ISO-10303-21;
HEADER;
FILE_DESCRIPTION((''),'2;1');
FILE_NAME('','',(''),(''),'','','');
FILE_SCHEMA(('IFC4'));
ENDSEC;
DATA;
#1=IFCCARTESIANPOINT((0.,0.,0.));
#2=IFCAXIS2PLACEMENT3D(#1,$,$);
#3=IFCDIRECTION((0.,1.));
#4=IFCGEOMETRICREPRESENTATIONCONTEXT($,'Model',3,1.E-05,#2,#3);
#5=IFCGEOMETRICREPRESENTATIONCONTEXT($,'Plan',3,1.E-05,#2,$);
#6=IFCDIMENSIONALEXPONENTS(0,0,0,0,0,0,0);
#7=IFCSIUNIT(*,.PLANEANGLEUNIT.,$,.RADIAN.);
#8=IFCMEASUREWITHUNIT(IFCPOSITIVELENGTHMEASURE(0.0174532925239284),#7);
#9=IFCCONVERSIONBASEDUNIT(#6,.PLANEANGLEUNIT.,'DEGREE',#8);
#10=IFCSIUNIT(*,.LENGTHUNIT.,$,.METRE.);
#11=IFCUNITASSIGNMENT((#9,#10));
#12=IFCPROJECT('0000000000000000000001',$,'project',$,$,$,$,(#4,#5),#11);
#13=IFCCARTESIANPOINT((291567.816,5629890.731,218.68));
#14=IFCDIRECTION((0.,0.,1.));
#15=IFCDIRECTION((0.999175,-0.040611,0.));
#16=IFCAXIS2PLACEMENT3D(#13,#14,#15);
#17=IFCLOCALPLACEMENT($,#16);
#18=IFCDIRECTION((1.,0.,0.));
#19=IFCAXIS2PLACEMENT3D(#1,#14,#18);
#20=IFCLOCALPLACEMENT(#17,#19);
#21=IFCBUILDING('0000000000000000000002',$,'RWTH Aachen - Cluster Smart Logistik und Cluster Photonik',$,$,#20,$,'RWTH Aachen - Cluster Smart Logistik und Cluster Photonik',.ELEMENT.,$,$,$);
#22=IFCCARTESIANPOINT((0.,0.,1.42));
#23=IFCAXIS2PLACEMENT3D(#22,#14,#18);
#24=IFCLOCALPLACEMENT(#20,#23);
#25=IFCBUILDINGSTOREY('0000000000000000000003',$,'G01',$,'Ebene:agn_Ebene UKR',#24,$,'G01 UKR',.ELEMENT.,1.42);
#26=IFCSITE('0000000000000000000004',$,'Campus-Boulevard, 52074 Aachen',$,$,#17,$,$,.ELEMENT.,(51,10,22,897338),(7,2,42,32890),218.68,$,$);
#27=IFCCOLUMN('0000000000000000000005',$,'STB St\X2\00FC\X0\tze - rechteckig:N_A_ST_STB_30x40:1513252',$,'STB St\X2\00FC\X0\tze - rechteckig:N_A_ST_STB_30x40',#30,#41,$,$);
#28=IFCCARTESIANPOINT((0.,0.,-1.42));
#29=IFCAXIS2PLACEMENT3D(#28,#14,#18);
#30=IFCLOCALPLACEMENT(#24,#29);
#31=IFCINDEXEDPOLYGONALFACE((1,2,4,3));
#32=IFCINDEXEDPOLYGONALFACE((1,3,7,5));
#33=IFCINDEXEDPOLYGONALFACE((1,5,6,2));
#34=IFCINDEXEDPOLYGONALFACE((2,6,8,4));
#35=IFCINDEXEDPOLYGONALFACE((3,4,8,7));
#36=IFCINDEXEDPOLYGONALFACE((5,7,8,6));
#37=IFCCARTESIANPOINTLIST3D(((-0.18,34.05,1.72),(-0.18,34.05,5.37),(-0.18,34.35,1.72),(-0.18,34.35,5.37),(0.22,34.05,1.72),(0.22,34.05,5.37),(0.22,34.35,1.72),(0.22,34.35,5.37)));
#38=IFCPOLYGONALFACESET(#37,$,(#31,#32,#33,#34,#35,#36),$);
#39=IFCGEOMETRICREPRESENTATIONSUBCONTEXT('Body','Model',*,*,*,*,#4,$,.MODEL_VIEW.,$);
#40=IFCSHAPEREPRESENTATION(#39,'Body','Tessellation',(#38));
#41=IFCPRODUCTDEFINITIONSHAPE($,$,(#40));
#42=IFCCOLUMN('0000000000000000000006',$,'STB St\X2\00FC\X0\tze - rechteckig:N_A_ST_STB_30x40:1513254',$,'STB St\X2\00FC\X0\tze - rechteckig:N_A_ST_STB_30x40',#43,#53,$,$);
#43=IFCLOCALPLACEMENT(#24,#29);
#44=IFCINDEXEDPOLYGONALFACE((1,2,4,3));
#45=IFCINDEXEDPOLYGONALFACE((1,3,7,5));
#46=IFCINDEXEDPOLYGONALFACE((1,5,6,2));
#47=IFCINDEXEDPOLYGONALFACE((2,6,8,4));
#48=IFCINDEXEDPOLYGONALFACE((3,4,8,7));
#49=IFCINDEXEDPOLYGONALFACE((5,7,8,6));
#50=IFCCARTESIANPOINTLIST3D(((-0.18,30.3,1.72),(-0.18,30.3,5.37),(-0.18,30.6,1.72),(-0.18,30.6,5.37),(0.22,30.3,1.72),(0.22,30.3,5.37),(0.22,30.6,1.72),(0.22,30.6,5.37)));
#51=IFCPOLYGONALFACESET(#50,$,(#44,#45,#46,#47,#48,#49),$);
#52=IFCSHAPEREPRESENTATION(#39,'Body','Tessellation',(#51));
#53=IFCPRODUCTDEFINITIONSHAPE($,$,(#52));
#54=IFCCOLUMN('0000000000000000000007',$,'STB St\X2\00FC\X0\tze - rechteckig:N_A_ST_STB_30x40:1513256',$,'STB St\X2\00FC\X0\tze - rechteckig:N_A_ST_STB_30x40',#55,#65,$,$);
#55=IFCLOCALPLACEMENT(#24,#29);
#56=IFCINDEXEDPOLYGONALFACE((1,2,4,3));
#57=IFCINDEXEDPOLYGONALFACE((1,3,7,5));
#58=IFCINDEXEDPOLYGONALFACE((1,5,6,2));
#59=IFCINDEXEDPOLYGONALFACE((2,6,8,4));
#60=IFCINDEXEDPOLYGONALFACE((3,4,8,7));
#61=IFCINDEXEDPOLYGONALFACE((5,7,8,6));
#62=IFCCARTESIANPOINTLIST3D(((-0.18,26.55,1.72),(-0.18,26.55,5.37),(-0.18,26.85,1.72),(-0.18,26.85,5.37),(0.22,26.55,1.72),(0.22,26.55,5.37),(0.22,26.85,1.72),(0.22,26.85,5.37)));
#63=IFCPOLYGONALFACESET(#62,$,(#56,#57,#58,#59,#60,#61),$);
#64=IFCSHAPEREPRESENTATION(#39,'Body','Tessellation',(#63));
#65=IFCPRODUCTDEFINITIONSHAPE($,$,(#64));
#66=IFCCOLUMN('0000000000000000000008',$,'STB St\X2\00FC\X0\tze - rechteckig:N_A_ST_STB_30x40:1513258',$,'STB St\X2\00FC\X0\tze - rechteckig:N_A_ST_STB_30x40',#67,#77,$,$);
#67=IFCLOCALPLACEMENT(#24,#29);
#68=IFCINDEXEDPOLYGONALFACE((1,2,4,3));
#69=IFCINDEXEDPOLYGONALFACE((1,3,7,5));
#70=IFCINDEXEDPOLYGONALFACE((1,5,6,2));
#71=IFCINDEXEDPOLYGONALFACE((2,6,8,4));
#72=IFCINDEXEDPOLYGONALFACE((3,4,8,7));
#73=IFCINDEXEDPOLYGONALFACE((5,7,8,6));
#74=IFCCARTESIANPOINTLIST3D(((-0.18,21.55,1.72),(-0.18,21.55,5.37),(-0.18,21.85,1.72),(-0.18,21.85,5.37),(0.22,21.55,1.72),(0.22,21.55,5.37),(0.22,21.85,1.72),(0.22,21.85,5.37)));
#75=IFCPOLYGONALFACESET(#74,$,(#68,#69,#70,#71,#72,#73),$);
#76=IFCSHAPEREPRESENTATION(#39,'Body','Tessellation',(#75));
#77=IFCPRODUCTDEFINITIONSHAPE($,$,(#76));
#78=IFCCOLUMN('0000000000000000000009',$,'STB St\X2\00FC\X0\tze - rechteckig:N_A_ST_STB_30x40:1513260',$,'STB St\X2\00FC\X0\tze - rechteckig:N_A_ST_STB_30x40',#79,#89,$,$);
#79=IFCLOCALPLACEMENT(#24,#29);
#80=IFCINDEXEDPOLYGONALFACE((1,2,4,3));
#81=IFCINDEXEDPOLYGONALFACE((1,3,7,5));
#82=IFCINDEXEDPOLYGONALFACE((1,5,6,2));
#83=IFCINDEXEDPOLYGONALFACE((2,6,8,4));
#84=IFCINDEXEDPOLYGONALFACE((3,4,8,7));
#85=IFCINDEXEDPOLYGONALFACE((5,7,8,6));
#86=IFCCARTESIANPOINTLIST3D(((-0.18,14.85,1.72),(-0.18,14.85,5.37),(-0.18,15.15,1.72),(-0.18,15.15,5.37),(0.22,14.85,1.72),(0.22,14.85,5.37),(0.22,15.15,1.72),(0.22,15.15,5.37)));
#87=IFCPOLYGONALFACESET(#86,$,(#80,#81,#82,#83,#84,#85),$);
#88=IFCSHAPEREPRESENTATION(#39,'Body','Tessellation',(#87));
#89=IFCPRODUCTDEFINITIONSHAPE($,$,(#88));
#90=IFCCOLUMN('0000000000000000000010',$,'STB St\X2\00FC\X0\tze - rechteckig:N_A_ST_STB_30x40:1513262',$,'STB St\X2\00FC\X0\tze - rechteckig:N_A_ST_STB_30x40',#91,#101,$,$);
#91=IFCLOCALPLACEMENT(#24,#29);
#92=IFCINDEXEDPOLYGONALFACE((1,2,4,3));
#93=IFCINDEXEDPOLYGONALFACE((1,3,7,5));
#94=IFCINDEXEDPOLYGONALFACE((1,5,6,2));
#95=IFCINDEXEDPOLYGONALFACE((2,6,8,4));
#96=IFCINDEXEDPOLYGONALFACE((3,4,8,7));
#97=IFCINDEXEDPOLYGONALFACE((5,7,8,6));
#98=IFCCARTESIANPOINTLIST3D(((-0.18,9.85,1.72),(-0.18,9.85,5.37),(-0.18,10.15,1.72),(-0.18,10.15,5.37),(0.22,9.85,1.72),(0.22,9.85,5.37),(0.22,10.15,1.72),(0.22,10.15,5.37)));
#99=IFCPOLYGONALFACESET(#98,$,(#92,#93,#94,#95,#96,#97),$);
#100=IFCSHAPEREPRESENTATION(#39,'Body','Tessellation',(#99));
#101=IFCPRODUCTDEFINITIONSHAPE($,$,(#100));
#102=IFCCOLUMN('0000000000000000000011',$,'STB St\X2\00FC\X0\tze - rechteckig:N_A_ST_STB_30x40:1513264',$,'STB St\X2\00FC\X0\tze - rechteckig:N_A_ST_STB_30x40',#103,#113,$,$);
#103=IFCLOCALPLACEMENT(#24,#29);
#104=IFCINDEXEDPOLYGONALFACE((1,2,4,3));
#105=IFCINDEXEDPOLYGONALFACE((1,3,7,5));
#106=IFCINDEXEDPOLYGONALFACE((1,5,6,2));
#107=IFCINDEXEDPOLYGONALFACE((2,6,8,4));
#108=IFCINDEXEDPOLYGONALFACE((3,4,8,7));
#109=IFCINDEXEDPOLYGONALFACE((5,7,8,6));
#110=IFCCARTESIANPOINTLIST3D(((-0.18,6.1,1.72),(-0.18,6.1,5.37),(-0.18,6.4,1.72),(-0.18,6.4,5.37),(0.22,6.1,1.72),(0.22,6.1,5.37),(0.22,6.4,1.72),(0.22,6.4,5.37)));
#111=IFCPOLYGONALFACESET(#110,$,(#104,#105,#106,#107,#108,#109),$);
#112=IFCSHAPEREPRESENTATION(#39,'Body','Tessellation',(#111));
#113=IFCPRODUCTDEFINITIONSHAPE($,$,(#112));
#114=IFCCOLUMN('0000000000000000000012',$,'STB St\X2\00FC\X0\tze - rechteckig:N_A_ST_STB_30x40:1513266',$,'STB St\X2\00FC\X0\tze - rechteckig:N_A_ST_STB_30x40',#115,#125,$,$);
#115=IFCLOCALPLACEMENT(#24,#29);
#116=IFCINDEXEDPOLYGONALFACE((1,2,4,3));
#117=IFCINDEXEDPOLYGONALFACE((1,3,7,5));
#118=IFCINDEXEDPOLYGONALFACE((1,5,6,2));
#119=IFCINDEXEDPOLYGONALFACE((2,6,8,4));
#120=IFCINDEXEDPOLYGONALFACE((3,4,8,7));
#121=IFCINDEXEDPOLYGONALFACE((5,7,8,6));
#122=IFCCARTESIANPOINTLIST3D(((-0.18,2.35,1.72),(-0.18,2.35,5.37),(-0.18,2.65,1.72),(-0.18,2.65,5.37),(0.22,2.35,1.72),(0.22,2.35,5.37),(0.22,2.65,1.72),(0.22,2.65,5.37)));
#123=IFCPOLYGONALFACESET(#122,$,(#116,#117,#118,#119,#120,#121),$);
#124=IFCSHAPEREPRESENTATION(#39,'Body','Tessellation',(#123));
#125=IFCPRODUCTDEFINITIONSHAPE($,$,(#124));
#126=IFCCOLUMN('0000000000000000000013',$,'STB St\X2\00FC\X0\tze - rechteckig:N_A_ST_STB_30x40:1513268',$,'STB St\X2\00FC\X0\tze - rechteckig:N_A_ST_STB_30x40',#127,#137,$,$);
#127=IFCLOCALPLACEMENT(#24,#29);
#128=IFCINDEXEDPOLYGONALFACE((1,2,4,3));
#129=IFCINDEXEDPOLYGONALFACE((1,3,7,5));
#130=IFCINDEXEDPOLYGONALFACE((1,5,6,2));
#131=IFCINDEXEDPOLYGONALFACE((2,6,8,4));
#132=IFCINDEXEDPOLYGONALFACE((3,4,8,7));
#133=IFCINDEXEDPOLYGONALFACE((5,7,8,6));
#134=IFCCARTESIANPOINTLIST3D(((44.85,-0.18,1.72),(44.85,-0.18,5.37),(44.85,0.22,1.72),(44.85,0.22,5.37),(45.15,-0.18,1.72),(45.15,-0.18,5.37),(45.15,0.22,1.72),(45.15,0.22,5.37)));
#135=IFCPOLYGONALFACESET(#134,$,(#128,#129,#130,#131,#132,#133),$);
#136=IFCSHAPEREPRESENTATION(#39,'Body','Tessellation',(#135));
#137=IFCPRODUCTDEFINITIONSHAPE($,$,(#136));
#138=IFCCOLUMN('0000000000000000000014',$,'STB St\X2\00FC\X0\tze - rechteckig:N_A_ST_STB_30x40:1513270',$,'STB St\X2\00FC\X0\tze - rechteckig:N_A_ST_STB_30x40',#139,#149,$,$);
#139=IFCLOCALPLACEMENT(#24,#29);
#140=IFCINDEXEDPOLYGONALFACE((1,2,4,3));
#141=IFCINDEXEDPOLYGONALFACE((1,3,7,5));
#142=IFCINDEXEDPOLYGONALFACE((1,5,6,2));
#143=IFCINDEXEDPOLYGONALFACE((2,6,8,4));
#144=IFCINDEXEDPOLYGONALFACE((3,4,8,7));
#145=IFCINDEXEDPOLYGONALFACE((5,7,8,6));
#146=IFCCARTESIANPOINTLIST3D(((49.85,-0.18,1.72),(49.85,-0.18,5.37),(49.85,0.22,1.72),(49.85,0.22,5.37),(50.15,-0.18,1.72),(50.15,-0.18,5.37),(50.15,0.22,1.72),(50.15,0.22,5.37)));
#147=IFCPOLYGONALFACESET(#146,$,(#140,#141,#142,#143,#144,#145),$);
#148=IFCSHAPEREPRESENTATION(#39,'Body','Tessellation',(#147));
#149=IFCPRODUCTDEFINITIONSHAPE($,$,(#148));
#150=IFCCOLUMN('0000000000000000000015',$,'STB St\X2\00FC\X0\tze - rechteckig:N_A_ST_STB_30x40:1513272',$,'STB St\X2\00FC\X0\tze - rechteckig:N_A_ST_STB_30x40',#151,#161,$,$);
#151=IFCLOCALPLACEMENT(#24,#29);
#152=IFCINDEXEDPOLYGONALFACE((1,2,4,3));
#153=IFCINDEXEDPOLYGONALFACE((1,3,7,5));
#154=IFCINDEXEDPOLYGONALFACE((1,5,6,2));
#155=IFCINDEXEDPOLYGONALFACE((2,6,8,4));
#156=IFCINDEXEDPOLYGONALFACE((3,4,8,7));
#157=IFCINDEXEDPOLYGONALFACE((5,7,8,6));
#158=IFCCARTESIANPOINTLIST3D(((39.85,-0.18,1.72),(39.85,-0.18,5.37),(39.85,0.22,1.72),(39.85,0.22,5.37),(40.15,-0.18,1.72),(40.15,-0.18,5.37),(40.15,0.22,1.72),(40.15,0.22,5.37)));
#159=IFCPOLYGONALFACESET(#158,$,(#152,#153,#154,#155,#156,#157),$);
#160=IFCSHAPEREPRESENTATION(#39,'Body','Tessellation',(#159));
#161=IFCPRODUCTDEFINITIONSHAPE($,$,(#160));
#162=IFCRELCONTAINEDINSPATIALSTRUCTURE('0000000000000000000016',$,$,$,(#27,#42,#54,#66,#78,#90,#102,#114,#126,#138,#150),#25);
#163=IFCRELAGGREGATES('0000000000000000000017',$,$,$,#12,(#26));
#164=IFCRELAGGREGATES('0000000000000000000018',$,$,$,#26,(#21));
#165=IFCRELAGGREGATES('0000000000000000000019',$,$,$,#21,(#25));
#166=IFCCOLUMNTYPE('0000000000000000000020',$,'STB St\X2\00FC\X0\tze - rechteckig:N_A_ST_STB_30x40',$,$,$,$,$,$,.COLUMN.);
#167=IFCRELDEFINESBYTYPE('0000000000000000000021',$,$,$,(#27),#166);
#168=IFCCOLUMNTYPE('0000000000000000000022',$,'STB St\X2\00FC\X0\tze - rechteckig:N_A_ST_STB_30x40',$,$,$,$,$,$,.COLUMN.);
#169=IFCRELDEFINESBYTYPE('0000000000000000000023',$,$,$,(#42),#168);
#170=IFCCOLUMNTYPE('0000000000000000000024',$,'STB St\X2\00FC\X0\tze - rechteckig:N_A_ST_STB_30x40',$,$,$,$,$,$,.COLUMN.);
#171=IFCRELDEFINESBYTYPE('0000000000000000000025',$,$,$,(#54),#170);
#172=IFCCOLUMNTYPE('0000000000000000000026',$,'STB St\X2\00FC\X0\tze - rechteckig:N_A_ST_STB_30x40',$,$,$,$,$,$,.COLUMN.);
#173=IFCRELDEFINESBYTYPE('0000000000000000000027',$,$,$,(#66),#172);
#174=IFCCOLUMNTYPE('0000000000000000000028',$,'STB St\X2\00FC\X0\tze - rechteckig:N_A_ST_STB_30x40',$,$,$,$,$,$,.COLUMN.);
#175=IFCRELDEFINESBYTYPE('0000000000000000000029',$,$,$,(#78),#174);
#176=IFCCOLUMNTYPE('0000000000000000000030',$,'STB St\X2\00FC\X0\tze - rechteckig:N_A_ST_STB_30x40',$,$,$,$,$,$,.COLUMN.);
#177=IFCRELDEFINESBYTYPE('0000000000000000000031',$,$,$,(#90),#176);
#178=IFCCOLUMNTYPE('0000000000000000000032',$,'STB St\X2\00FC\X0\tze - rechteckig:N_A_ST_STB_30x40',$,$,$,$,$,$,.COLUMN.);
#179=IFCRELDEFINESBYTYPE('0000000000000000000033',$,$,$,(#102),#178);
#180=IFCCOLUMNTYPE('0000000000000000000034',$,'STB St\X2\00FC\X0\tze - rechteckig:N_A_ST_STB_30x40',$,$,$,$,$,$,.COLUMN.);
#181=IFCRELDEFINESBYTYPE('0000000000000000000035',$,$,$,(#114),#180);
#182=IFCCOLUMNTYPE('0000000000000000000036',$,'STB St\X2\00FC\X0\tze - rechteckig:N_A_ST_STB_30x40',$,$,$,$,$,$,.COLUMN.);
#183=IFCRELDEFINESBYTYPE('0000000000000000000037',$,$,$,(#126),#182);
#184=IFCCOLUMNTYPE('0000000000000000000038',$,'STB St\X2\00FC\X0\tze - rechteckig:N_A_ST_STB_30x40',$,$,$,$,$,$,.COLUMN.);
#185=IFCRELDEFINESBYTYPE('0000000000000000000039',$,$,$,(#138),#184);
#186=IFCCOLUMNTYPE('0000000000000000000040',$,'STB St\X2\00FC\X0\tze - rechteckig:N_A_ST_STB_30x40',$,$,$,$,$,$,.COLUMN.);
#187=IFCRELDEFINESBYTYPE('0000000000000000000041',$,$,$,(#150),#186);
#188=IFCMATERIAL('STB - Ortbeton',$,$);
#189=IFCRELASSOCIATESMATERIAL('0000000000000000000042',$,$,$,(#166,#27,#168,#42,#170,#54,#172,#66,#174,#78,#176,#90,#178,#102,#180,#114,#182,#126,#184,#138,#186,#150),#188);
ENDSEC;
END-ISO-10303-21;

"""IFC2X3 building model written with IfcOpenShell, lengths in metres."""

from ifc_helpers import new_model, entity, si_unit, converted_unit, direction, frame, frame_2d, origin, origin_with_axes, origin_2d_with_axis, place, context, subcontext, project, spatial, rectangle, extrude, source, transform, mapped, material, type_object, element, save


model = new_model("IFC2X3")

# Units and contexts
model_context = context("Model", 3, precision=1e-05, world=origin(), true_north=direction((0.0, 1.0)))
plan_context = context("Plan", 3, precision=1e-05, world=origin())
body_context = subcontext(model_context, "Body", "Model", "MODEL_VIEW")
ifc_project = project(units=[converted_unit("PLANEANGLEUNIT", "DEGREE", entity("IfcPositiveLengthMeasure", 0.0174532925239284), si_unit("PLANEANGLEUNIT", "RADIAN"), dimensions=[0, 0, 0, 0, 0, 0, 0]), si_unit("LENGTHUNIT", "METRE")], contexts=[model_context, plan_context])

# Site, building, storey
site_placement = place(None, frame((291567.816, 5629890.731, 218.68), z_axis=(0.0, 0.0, 1.0), x_axis=(0.999175, -0.040611, 0.0)))
site = spatial("IfcSite", under=ifc_project, at=site_placement, Name="Campus-Boulevard, 52074 Aachen", CompositionType="ELEMENT", RefLatitude=(51, 10, 22, 897338), RefLongitude=(7, 2, 42, 32890), RefElevation=218.68)
building_placement = place(site_placement, origin_with_axes())
building = spatial("IfcBuilding", under=site, at=building_placement, Name="RWTH Aachen - Cluster Smart Logistik und Cluster Photonik", LongName="RWTH Aachen - Cluster Smart Logistik und Cluster Photonik", CompositionType="ELEMENT")
storey_placement = place(building_placement, frame((0.0, 0.0, 1.42), z_axis=(0.0, 0.0, 1.0), x_axis=(1.0, 0.0, 0.0)))
storey = spatial("IfcBuildingStorey", under=building, at=storey_placement, Name="G01", ObjectType="Ebene:agn_Ebene UKR", LongName="G01 UKR", CompositionType="ELEMENT", Elevation=1.42)

# Columns
ifc_material = material(Name="STB - Ortbeton")
column_type_1 = type_object("IfcColumnType", Name="STB Stütze - rechteckig:N_A_ST_STB_30x40", PredefinedType="COLUMN", material=ifc_material)
shared_shape_1 = source(origin(), body_context, "Body", "SweptSolid", [
    extrude(rectangle(XDim=0.3, YDim=0.4, at=origin_2d_with_axis()), frame((0.02, 34.2, 1.72), z_axis=(0.0, 0.0, 1.0), x_axis=(0.0, -1.0, 0.0)), (0.0, 0.0, 1.0), 3.65),
])
column_1_placement = place(storey_placement, frame((0.0, 0.0, -1.42), z_axis=(0.0, 0.0, 1.0), x_axis=(1.0, 0.0, 0.0)))
element("IfcColumn", 1, at=column_1_placement, inside=storey, type_object=column_type_1, material=ifc_material, Name="STB Stütze - rechteckig:N_A_ST_STB_30x40:1513252", ObjectType="STB Stütze - rechteckig:N_A_ST_STB_30x40", context=body_context, shape_type="MappedRepresentation", body=[
    mapped(shared_shape_1, transform((0.0, 0.0, 0.0), scale=1.0)),
])
column_type_2 = type_object("IfcColumnType", Name="STB Stütze - rechteckig:N_A_ST_STB_30x40", PredefinedType="COLUMN", material=ifc_material)
shared_shape_2 = source(origin(), body_context, "Body", "SweptSolid", [
    extrude(rectangle(XDim=0.3, YDim=0.4, at=origin_2d_with_axis()), frame((0.02, 30.45, 1.72), z_axis=(0.0, 0.0, 1.0), x_axis=(0.0, -1.0, 0.0)), (0.0, 0.0, 1.0), 3.65),
])
column_2_placement = place(storey_placement, frame((0.0, 0.0, -1.42), z_axis=(0.0, 0.0, 1.0), x_axis=(1.0, 0.0, 0.0)))
element("IfcColumn", 2, at=column_2_placement, inside=storey, type_object=column_type_2, material=ifc_material, Name="STB Stütze - rechteckig:N_A_ST_STB_30x40:1513254", ObjectType="STB Stütze - rechteckig:N_A_ST_STB_30x40", context=body_context, shape_type="MappedRepresentation", body=[
    mapped(shared_shape_2, transform((0.0, 0.0, 0.0), scale=1.0)),
])
column_type_3 = type_object("IfcColumnType", Name="STB Stütze - rechteckig:N_A_ST_STB_30x40", PredefinedType="COLUMN", material=ifc_material)
shared_shape_3 = source(origin(), body_context, "Body", "SweptSolid", [
    extrude(rectangle(XDim=0.3, YDim=0.4, at=origin_2d_with_axis()), frame((0.02, 26.7, 1.72), z_axis=(0.0, 0.0, 1.0), x_axis=(0.0, -1.0, 0.0)), (0.0, 0.0, 1.0), 3.65),
])
column_3_placement = place(storey_placement, frame((0.0, 0.0, -1.42), z_axis=(0.0, 0.0, 1.0), x_axis=(1.0, 0.0, 0.0)))
element("IfcColumn", 3, at=column_3_placement, inside=storey, type_object=column_type_3, material=ifc_material, Name="STB Stütze - rechteckig:N_A_ST_STB_30x40:1513256", ObjectType="STB Stütze - rechteckig:N_A_ST_STB_30x40", context=body_context, shape_type="MappedRepresentation", body=[
    mapped(shared_shape_3, transform((0.0, 0.0, 0.0), scale=1.0)),
])
column_type_4 = type_object("IfcColumnType", Name="STB Stütze - rechteckig:N_A_ST_STB_30x40", PredefinedType="COLUMN", material=ifc_material)
shared_shape_4 = source(origin(), body_context, "Body", "SweptSolid", [
    extrude(rectangle(XDim=0.3, YDim=0.4, at=origin_2d_with_axis()), frame((0.02, 21.7, 1.72), z_axis=(0.0, 0.0, 1.0), x_axis=(0.0, -1.0, 0.0)), (0.0, 0.0, 1.0), 3.65),
])
column_4_placement = place(storey_placement, frame((0.0, 0.0, -1.42), z_axis=(0.0, 0.0, 1.0), x_axis=(1.0, 0.0, 0.0)))
element("IfcColumn", 4, at=column_4_placement, inside=storey, type_object=column_type_4, material=ifc_material, Name="STB Stütze - rechteckig:N_A_ST_STB_30x40:1513258", ObjectType="STB Stütze - rechteckig:N_A_ST_STB_30x40", context=body_context, shape_type="MappedRepresentation", body=[
    mapped(shared_shape_4, transform((0.0, 0.0, 0.0), scale=1.0)),
])
column_type_5 = type_object("IfcColumnType", Name="STB Stütze - rechteckig:N_A_ST_STB_30x40", PredefinedType="COLUMN", material=ifc_material)
shared_shape_5 = source(origin(), body_context, "Body", "SweptSolid", [
    extrude(rectangle(XDim=0.3, YDim=0.4, at=origin_2d_with_axis()), frame((0.02, 15.0, 1.72), z_axis=(0.0, 0.0, 1.0), x_axis=(0.0, -1.0, 0.0)), (0.0, 0.0, 1.0), 3.65),
])
column_5_placement = place(storey_placement, frame((0.0, 0.0, -1.42), z_axis=(0.0, 0.0, 1.0), x_axis=(1.0, 0.0, 0.0)))
element("IfcColumn", 5, at=column_5_placement, inside=storey, type_object=column_type_5, material=ifc_material, Name="STB Stütze - rechteckig:N_A_ST_STB_30x40:1513260", ObjectType="STB Stütze - rechteckig:N_A_ST_STB_30x40", context=body_context, shape_type="MappedRepresentation", body=[
    mapped(shared_shape_5, transform((0.0, 0.0, 0.0), scale=1.0)),
])
column_type_6 = type_object("IfcColumnType", Name="STB Stütze - rechteckig:N_A_ST_STB_30x40", PredefinedType="COLUMN", material=ifc_material)
shared_shape_6 = source(origin(), body_context, "Body", "SweptSolid", [
    extrude(rectangle(XDim=0.3, YDim=0.4, at=origin_2d_with_axis()), frame((0.02, 10.0, 1.72), z_axis=(0.0, 0.0, 1.0), x_axis=(0.0, -1.0, 0.0)), (0.0, 0.0, 1.0), 3.65),
])
column_6_placement = place(storey_placement, frame((0.0, 0.0, -1.42), z_axis=(0.0, 0.0, 1.0), x_axis=(1.0, 0.0, 0.0)))
element("IfcColumn", 6, at=column_6_placement, inside=storey, type_object=column_type_6, material=ifc_material, Name="STB Stütze - rechteckig:N_A_ST_STB_30x40:1513262", ObjectType="STB Stütze - rechteckig:N_A_ST_STB_30x40", context=body_context, shape_type="MappedRepresentation", body=[
    mapped(shared_shape_6, transform((0.0, 0.0, 0.0), scale=1.0)),
])
column_type_7 = type_object("IfcColumnType", Name="STB Stütze - rechteckig:N_A_ST_STB_30x40", PredefinedType="COLUMN", material=ifc_material)
shared_shape_7 = source(origin(), body_context, "Body", "SweptSolid", [
    extrude(rectangle(XDim=0.3, YDim=0.4, at=frame_2d((0.0, 0.0), x_axis=(1.0, 0.0))), frame((0.02, 6.25, 1.72), z_axis=(0.0, 0.0, 1.0), x_axis=(0.0, -1.0, 0.0)), (0.0, 0.0, 1.0), 3.65),
])
column_7_placement = place(storey_placement, frame((0.0, 0.0, -1.42), z_axis=(0.0, 0.0, 1.0), x_axis=(1.0, 0.0, 0.0)))
element("IfcColumn", 7, at=column_7_placement, inside=storey, type_object=column_type_7, material=ifc_material, Name="STB Stütze - rechteckig:N_A_ST_STB_30x40:1513264", ObjectType="STB Stütze - rechteckig:N_A_ST_STB_30x40", context=body_context, shape_type="MappedRepresentation", body=[
    mapped(shared_shape_7, transform((0.0, 0.0, 0.0), scale=1.0)),
])
column_type_8 = type_object("IfcColumnType", Name="STB Stütze - rechteckig:N_A_ST_STB_30x40", PredefinedType="COLUMN", material=ifc_material)
shared_shape_8 = source(origin(), body_context, "Body", "SweptSolid", [
    extrude(rectangle(XDim=0.3, YDim=0.4, at=frame_2d((0.0, 0.0), x_axis=(1.0, 0.0))), frame((0.02, 2.5, 1.72), z_axis=(0.0, 0.0, 1.0), x_axis=(0.0, -1.0, 0.0)), (0.0, 0.0, 1.0), 3.65),
])
column_8_placement = place(storey_placement, frame((0.0, 0.0, -1.42), z_axis=(0.0, 0.0, 1.0), x_axis=(1.0, 0.0, 0.0)))
element("IfcColumn", 8, at=column_8_placement, inside=storey, type_object=column_type_8, material=ifc_material, Name="STB Stütze - rechteckig:N_A_ST_STB_30x40:1513266", ObjectType="STB Stütze - rechteckig:N_A_ST_STB_30x40", context=body_context, shape_type="MappedRepresentation", body=[
    mapped(shared_shape_8, transform((0.0, 0.0, 0.0), scale=1.0)),
])
column_type_9 = type_object("IfcColumnType", Name="STB Stütze - rechteckig:N_A_ST_STB_30x40", PredefinedType="COLUMN", material=ifc_material)
shared_shape_9 = source(origin(), body_context, "Body", "SweptSolid", [
    extrude(rectangle(XDim=0.4, YDim=0.3, at=origin_2d_with_axis()), frame((45.0, 0.02, 1.72), z_axis=(0.0, 0.0, 1.0), x_axis=(0.0, -1.0, 0.0)), (0.0, 0.0, 1.0), 3.65),
])
column_9_placement = place(storey_placement, frame((0.0, 0.0, -1.42), z_axis=(0.0, 0.0, 1.0), x_axis=(1.0, 0.0, 0.0)))
element("IfcColumn", 9, at=column_9_placement, inside=storey, type_object=column_type_9, material=ifc_material, Name="STB Stütze - rechteckig:N_A_ST_STB_30x40:1513268", ObjectType="STB Stütze - rechteckig:N_A_ST_STB_30x40", context=body_context, shape_type="MappedRepresentation", body=[
    mapped(shared_shape_9, transform((0.0, 0.0, 0.0), scale=1.0)),
])
column_type_10 = type_object("IfcColumnType", Name="STB Stütze - rechteckig:N_A_ST_STB_30x40", PredefinedType="COLUMN", material=ifc_material)
shared_shape_10 = source(origin(), body_context, "Body", "SweptSolid", [
    extrude(rectangle(XDim=0.4, YDim=0.3, at=origin_2d_with_axis()), frame((50.0, 0.02, 1.72), z_axis=(0.0, 0.0, 1.0), x_axis=(0.0, -1.0, 0.0)), (0.0, 0.0, 1.0), 3.65),
])
column_10_placement = place(storey_placement, frame((0.0, 0.0, -1.42), z_axis=(0.0, 0.0, 1.0), x_axis=(1.0, 0.0, 0.0)))
element("IfcColumn", 10, at=column_10_placement, inside=storey, type_object=column_type_10, material=ifc_material, Name="STB Stütze - rechteckig:N_A_ST_STB_30x40:1513270", ObjectType="STB Stütze - rechteckig:N_A_ST_STB_30x40", context=body_context, shape_type="MappedRepresentation", body=[
    mapped(shared_shape_10, transform((0.0, 0.0, 0.0), scale=1.0)),
])
column_type_11 = type_object("IfcColumnType", Name="STB Stütze - rechteckig:N_A_ST_STB_30x40", PredefinedType="COLUMN", material=ifc_material)
shared_shape_11 = source(origin(), body_context, "Body", "SweptSolid", [
    extrude(rectangle(XDim=0.4, YDim=0.3, at=origin_2d_with_axis()), frame((40.0, 0.02, 1.72), z_axis=(0.0, 0.0, 1.0), x_axis=(0.0, -1.0, 0.0)), (0.0, 0.0, 1.0), 3.65),
])
column_11_placement = place(storey_placement, frame((0.0, 0.0, -1.42), z_axis=(0.0, 0.0, 1.0), x_axis=(1.0, 0.0, 0.0)))
element("IfcColumn", 11, at=column_11_placement, inside=storey, type_object=column_type_11, material=ifc_material, Name="STB Stütze - rechteckig:N_A_ST_STB_30x40:1513272", ObjectType="STB Stütze - rechteckig:N_A_ST_STB_30x40", context=body_context, shape_type="MappedRepresentation", body=[
    mapped(shared_shape_11, transform((0.0, 0.0, 0.0), scale=1.0)),
])

save(model, "model.ifc")
